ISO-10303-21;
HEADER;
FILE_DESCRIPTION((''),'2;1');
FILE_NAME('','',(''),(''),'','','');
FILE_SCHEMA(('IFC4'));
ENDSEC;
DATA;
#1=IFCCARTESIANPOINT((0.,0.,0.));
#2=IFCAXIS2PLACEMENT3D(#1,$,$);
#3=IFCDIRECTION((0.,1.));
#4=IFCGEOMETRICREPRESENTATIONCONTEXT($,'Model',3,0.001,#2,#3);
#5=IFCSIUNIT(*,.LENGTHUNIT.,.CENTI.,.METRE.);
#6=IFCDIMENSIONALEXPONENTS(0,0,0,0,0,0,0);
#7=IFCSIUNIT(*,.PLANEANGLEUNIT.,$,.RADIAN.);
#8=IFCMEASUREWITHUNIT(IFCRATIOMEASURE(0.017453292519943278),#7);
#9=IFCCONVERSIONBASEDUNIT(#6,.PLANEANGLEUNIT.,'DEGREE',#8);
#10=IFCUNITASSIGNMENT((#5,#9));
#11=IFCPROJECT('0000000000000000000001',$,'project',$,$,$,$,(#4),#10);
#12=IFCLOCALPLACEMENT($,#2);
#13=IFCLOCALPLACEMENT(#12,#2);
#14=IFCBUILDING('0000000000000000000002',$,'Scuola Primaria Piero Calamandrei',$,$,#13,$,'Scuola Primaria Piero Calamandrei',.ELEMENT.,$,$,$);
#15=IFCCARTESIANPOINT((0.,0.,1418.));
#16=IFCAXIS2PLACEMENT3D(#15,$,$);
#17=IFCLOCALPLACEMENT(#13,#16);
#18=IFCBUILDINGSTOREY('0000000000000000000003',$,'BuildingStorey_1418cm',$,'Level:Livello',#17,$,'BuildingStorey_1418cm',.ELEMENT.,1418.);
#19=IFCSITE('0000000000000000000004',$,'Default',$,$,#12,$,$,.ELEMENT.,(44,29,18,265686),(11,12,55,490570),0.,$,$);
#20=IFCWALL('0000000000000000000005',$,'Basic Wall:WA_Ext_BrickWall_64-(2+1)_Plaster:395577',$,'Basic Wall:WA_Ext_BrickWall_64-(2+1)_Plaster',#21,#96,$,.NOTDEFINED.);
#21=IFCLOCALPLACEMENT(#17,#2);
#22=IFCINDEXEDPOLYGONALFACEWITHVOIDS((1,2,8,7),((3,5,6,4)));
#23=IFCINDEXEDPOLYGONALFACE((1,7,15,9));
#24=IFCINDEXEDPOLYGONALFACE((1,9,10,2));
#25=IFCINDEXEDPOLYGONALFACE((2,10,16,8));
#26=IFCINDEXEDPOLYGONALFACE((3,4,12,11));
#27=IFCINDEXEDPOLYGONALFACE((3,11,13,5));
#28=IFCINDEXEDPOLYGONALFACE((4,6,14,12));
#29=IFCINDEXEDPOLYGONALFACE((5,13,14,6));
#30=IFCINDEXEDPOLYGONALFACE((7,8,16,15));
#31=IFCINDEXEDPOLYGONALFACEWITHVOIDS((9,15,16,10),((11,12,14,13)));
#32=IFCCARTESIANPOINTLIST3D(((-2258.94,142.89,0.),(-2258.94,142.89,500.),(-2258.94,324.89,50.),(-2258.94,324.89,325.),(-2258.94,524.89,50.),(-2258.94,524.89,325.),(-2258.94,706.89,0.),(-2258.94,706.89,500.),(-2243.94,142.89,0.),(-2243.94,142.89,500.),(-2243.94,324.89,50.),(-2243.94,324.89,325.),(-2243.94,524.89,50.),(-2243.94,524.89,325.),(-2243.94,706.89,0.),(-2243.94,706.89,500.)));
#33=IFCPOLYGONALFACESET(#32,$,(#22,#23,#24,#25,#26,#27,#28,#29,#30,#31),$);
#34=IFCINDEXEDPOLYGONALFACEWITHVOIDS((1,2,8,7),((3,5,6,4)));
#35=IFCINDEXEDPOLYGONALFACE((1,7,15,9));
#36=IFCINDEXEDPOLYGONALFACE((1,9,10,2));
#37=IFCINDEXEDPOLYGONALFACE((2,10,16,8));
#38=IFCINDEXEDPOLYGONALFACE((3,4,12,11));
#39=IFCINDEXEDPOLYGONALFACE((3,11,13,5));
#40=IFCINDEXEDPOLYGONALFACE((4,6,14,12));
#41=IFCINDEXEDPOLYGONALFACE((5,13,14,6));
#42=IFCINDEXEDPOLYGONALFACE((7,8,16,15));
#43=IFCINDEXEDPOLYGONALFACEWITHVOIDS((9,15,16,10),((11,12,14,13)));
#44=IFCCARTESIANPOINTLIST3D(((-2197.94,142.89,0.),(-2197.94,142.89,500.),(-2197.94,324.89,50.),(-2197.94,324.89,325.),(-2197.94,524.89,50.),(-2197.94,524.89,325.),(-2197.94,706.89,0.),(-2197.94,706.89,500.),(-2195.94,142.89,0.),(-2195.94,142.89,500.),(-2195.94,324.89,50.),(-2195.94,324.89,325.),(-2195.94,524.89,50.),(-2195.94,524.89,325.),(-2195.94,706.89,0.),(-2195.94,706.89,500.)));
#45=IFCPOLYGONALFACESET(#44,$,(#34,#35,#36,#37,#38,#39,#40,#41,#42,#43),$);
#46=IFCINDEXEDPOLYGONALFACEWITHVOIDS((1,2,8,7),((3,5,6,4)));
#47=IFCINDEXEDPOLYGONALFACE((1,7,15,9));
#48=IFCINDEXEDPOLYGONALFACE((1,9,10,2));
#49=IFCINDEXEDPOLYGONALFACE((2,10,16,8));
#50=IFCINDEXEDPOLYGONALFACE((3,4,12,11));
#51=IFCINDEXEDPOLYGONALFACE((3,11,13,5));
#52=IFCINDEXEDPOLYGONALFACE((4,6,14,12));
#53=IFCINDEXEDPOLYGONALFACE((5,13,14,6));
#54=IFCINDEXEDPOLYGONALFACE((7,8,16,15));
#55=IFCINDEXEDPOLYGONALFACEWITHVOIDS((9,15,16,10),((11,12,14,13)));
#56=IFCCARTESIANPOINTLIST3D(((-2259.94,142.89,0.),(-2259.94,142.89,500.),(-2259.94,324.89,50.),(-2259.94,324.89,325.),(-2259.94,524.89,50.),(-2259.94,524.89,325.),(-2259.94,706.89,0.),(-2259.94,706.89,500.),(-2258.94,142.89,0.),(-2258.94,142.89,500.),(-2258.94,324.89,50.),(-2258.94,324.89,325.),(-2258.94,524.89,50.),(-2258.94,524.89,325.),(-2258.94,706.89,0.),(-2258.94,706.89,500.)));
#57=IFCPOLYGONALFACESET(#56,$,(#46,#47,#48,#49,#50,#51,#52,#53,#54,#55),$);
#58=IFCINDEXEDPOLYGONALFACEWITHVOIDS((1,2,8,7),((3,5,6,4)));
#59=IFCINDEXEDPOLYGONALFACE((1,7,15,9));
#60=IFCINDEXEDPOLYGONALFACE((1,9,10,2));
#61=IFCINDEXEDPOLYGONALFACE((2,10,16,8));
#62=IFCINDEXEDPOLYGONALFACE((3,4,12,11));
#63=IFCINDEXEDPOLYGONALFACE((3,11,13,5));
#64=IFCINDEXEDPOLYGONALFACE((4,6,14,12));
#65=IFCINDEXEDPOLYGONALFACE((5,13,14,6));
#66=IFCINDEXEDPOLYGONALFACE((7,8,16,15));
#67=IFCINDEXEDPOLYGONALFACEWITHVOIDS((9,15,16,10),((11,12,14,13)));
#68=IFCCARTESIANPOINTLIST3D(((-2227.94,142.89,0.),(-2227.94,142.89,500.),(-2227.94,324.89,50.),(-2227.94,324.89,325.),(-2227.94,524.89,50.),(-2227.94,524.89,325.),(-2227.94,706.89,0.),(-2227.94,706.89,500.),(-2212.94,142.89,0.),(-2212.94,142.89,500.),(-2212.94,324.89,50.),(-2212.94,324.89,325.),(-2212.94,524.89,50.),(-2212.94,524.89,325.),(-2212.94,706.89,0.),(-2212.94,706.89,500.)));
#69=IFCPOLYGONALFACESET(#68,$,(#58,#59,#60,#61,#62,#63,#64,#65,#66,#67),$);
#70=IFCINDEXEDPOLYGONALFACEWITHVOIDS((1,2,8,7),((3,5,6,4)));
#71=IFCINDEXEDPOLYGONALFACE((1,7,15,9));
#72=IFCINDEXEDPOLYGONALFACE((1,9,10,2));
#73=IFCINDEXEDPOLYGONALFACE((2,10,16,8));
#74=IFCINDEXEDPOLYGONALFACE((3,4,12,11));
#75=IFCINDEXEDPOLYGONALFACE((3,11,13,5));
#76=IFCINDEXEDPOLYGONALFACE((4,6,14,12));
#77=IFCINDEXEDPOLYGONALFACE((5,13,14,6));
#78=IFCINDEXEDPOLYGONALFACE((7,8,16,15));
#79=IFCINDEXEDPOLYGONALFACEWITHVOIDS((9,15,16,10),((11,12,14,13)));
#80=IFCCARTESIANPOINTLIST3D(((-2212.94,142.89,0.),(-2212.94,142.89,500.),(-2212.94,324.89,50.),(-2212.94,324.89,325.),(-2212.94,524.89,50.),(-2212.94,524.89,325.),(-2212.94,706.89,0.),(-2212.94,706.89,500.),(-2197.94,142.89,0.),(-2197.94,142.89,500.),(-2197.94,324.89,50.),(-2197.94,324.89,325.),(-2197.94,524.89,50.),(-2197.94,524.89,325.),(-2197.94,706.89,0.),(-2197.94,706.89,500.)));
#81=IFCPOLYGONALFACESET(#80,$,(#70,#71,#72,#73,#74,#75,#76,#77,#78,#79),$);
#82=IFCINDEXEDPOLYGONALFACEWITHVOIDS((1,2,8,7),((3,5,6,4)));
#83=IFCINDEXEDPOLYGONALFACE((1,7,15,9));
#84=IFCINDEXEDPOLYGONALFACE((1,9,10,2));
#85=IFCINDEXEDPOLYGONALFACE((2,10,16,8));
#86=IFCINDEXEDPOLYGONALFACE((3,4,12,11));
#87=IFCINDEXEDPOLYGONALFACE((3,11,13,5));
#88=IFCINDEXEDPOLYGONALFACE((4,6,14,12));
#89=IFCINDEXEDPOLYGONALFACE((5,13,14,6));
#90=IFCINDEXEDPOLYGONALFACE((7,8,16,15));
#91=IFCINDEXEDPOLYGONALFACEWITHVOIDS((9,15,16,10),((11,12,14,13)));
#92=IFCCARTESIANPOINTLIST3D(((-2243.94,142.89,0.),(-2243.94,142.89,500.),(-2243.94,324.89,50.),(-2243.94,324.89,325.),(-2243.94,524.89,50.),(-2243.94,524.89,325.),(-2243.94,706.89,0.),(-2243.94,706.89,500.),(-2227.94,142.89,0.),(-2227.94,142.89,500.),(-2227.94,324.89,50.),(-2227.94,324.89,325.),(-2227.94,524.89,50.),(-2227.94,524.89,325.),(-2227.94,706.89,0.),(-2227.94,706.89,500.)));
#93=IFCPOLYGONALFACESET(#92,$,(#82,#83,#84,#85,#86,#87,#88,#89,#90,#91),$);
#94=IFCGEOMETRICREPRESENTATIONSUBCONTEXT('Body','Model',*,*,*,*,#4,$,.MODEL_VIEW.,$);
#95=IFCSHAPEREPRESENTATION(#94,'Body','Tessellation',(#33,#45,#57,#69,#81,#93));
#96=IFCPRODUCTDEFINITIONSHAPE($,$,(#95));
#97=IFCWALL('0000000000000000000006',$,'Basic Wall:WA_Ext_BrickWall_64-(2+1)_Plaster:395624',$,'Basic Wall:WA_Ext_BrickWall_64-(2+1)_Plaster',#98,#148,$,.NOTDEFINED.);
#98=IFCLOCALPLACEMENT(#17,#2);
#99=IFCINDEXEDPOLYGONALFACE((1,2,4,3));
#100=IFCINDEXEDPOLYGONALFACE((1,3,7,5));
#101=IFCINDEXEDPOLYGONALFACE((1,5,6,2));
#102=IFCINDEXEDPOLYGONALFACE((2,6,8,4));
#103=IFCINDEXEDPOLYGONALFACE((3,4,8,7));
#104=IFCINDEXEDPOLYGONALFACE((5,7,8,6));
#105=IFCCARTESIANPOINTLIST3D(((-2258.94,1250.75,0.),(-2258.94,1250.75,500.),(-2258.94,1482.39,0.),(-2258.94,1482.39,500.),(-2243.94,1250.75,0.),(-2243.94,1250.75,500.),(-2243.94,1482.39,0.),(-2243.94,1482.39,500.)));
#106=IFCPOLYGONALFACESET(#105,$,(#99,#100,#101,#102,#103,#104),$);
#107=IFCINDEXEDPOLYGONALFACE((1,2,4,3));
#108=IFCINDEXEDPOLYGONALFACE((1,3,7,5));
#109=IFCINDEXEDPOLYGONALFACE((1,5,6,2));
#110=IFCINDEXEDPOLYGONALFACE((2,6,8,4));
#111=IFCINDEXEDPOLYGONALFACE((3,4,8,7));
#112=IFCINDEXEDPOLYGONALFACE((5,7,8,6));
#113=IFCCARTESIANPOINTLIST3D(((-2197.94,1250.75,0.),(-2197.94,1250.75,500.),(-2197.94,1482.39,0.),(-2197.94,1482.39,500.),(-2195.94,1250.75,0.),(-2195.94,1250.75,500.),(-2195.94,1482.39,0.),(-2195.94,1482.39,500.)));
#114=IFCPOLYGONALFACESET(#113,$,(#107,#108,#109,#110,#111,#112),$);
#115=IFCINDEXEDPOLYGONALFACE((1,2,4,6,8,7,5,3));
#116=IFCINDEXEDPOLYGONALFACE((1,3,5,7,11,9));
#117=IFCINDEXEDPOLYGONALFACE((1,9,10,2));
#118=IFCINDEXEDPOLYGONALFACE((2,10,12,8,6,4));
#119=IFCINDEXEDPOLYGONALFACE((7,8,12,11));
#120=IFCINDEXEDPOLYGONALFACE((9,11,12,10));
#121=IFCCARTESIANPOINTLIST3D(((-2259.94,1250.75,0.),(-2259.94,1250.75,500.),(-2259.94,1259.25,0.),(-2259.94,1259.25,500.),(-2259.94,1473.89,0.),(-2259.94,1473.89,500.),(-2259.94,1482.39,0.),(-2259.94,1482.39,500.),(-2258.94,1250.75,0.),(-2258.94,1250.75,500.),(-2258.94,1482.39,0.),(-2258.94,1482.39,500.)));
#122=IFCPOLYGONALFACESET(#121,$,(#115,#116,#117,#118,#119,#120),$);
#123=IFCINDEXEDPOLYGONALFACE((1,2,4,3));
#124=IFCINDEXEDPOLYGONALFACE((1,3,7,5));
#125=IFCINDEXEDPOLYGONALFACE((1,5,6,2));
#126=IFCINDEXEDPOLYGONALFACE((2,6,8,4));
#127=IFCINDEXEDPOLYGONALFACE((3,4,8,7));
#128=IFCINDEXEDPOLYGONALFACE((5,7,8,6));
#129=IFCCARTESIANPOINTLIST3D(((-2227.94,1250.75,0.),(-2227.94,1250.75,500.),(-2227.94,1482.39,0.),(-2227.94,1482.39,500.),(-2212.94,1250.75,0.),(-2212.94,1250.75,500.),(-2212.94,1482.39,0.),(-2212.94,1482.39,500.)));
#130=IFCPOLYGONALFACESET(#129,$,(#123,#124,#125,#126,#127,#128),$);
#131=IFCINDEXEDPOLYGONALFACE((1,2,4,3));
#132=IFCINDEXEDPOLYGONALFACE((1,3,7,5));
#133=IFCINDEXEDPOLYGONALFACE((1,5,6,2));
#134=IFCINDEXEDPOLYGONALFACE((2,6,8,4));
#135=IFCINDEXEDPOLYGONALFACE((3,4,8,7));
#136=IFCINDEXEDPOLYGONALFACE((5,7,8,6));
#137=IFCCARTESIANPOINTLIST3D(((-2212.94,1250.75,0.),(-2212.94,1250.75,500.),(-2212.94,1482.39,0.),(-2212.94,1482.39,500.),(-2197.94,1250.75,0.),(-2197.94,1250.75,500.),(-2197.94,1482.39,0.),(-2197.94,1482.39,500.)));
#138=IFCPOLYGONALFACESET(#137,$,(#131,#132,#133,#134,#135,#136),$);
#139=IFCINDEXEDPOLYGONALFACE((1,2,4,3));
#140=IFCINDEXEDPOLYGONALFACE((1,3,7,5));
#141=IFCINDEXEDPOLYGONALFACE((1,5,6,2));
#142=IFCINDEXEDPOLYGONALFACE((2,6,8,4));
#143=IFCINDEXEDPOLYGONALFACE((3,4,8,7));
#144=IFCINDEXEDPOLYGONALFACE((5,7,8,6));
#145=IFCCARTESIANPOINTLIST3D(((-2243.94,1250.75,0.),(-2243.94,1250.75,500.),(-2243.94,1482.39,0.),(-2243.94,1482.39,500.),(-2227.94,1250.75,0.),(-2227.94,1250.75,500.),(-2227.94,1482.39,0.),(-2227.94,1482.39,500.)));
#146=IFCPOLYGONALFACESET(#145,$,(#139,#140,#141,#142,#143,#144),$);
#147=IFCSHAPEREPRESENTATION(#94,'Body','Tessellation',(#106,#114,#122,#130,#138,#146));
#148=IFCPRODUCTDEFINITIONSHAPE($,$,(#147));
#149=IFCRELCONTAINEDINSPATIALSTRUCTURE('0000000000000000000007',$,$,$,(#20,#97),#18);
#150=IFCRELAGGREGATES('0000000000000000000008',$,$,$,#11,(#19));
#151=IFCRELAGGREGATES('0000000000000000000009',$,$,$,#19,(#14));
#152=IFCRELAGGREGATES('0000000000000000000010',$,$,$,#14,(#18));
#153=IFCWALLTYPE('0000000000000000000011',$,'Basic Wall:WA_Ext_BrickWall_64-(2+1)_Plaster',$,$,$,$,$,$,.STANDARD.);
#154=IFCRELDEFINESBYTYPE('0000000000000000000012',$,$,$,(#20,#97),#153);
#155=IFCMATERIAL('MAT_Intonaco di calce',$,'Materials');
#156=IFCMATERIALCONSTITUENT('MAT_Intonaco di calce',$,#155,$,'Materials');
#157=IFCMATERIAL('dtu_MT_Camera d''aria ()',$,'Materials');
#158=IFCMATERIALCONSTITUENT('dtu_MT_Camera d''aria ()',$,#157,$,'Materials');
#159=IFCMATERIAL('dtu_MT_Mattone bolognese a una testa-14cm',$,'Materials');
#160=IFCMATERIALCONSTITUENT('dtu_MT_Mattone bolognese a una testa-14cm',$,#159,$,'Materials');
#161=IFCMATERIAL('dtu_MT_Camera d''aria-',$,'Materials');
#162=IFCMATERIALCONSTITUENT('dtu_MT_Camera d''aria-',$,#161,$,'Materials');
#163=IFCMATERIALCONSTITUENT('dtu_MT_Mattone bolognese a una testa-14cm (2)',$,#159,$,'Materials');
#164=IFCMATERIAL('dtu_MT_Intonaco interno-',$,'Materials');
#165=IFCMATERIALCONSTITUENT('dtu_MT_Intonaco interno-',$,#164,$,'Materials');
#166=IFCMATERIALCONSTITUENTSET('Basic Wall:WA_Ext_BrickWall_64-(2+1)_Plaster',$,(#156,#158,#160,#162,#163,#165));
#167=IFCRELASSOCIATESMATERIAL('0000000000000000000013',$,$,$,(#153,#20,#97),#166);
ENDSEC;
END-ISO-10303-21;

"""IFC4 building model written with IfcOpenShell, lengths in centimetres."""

from ifc_helpers import new_model, entity, si_unit, converted_unit, direction, frame, origin, place, context, subcontext, project, spatial, indexed_curve, outline, extrude, material, constituent, constituent_set, type_object, element, save


model = new_model("IFC4")

# Units and contexts
model_context = context("Model", 3, precision=0.001, world=origin(), true_north=direction((0.0, 1.0)))
body_context = subcontext(model_context, "Body", "Model", "MODEL_VIEW")
ifc_project = project(units=[si_unit("LENGTHUNIT", "METRE", prefix="CENTI"), converted_unit("PLANEANGLEUNIT", "DEGREE", entity("IfcRatioMeasure", 0.017453292519943278), si_unit("PLANEANGLEUNIT", "RADIAN"), dimensions=[0, 0, 0, 0, 0, 0, 0])], contexts=[model_context])

# Site, building, storey
site_placement = place(None, origin())
site = spatial("IfcSite", under=ifc_project, at=site_placement, Name="Default", CompositionType="ELEMENT", RefLatitude=(44, 29, 18, 265686), RefLongitude=(11, 12, 55, 490570), RefElevation=0.0)
building_placement = place(site_placement, origin())
building = spatial("IfcBuilding", under=site, at=building_placement, Name="Scuola Primaria Piero Calamandrei", LongName="Scuola Primaria Piero Calamandrei", CompositionType="ELEMENT")
storey_placement = place(building_placement, frame((0.0, 0.0, 1418.0)))
storey = spatial("IfcBuildingStorey", under=building, at=storey_placement, Name="BuildingStorey_1418cm", ObjectType="Level:Livello", LongName="BuildingStorey_1418cm", CompositionType="ELEMENT", Elevation=1418.0)

# Shared definitions
ifc_material_1 = material(Name="dtu_MT_Intonaco interno-", Category="Materials")

# Shared definitions
ifc_material_2 = material(Name="MAT_Intonaco di calce", Category="Materials")
ifc_constituent_1 = constituent(ifc_material_2, Name="MAT_Intonaco di calce", Category="Materials")
ifc_material_3 = material(Name="dtu_MT_Camera d'aria ()", Category="Materials")
ifc_constituent_2 = constituent(ifc_material_3, Name="dtu_MT_Camera d'aria ()", Category="Materials")
ifc_material_4 = material(Name="dtu_MT_Mattone bolognese a una testa-14cm", Category="Materials")
ifc_constituent_3 = constituent(ifc_material_4, Name="dtu_MT_Mattone bolognese a una testa-14cm", Category="Materials")
ifc_material_5 = material(Name="dtu_MT_Camera d'aria-", Category="Materials")
ifc_constituent_4 = constituent(ifc_material_5, Name="dtu_MT_Camera d'aria-", Category="Materials")
ifc_constituent_5 = constituent(ifc_material_4, Name="dtu_MT_Mattone bolognese a una testa-14cm (2)", Category="Materials")
ifc_constituent_6 = constituent(ifc_material_1, Name="dtu_MT_Intonaco interno-", Category="Materials")
ifc_constituent_set_1 = constituent_set(constituents=[ifc_constituent_1, ifc_constituent_2, ifc_constituent_3, ifc_constituent_4, ifc_constituent_5, ifc_constituent_6], Name="Basic Wall:WA_Ext_BrickWall_64-(2+1)_Plaster")
wall_type_1 = type_object("IfcWallType", Name="Basic Wall:WA_Ext_BrickWall_64-(2+1)_Plaster", PredefinedType="STANDARD", material=ifc_constituent_set_1)

# Wall, opening
wall_1_placement = place(storey_placement, frame((-2227.94, 706.89, 0.0), z_axis=(0.0, 0.0, 1.0), x_axis=(0.0, -1.0, 0.0)))
wall_1 = element("IfcWall", 1, at=wall_1_placement, inside=storey, type_object=wall_type_1, material=ifc_constituent_set_1, Name="Basic Wall:WA_Ext_BrickWall_64-(2+1)_Plaster:395577", ObjectType="Basic Wall:WA_Ext_BrickWall_64-(2+1)_Plaster", PredefinedType="NOTDEFINED", context=body_context, shape_type="SweptSolid", body=[
    extrude(outline(indexed_curve([(-250.0, -282.0), (250.0, -282.0), (250.0, 282.0), (-250.0, 282.0), (-250.0, -282.0)], self_intersect=False), holes=[indexed_curve([(-200.0, -100.0), (-200.0, 100.0), (75.0, 100.0), (75.0, -100.0), (-200.0, -100.0)], self_intersect=False)]), frame((282.0, -31.0, 250.0), z_axis=(0.0, 1.0, 0.0), x_axis=(0.0, 0.0, 1.0)), (0.0, 0.0, 1.0), 15.0),
    extrude(outline(indexed_curve([(-250.0, -282.0), (250.0, -282.0), (250.0, 282.0), (-250.0, 282.0), (-250.0, -282.0)], self_intersect=False), holes=[indexed_curve([(-200.0, -100.0), (-200.0, 100.0), (75.0, 100.0), (75.0, -100.0), (-200.0, -100.0)], self_intersect=False)]), frame((282.0, 30.0, 250.0), z_axis=(0.0, 1.0, 0.0), x_axis=(0.0, 0.0, 1.0)), (0.0, 0.0, 1.0), 2.0),
    extrude(outline(indexed_curve([(-250.0, -282.0), (250.0, -282.0), (250.0, -273.5), (250.0, 273.5), (250.0, 282.0), (-250.0, 282.0), (-250.0, 273.5), (-250.0, -273.5), (-250.0, -282.0)], self_intersect=False), holes=[indexed_curve([(75.0, -100.0), (-200.0, -100.0), (-200.0, 100.0), (75.0, 100.0), (75.0, -100.0)], self_intersect=False)]), frame((282.0, -32.0, 250.0), z_axis=(0.0, 1.0, 0.0), x_axis=(0.0, 0.0, 1.0)), (0.0, 0.0, 1.0), 1.0),
    extrude(outline(indexed_curve([(-250.0, -282.0), (250.0, -282.0), (250.0, 282.0), (-250.0, 282.0), (-250.0, -282.0)], self_intersect=False), holes=[indexed_curve([(-200.0, -100.0), (-200.0, 100.0), (75.0, 100.0), (75.0, -100.0), (-200.0, -100.0)], self_intersect=False)]), frame((282.0, 0.0, 250.0), z_axis=(0.0, 1.0, 0.0), x_axis=(0.0, 0.0, 1.0)), (0.0, 0.0, 1.0), 15.0),
    extrude(outline(indexed_curve([(-250.0, -282.0), (250.0, -282.0), (250.0, 282.0), (-250.0, 282.0), (-250.0, -282.0)], self_intersect=False), holes=[indexed_curve([(-200.0, -100.0), (-200.0, 100.0), (75.0, 100.0), (75.0, -100.0), (-200.0, -100.0)], self_intersect=False)]), frame((282.0, 15.0, 250.0), z_axis=(0.0, 1.0, 0.0), x_axis=(0.0, 0.0, 1.0)), (0.0, 0.0, 1.0), 15.0),
    extrude(outline(indexed_curve([(-250.0, -282.0), (250.0, -282.0), (250.0, 282.0), (-250.0, 282.0), (-250.0, -282.0)], self_intersect=False), holes=[indexed_curve([(-200.0, -100.0), (-200.0, 100.0), (75.0, 100.0), (75.0, -100.0), (-200.0, -100.0)], self_intersect=False)]), frame((282.0, -16.0, 250.0), z_axis=(0.0, 1.0, 0.0), x_axis=(0.0, 0.0, 1.0)), (0.0, 0.0, 1.0), 16.0),
])
opening_1_placement = place(wall_1_placement, frame((182.0, -32.0, 50.0)))
element("IfcOpeningElement", 2, at=opening_1_placement, cuts=wall_1, PredefinedType="OPENING", context=body_context, shape_type="SweptSolid", body=[
    extrude(outline(indexed_curve([(275.0, 0.0), (275.0, 200.0), (0.0, 200.0), (0.0, 0.0), (275.0, 0.0)], self_intersect=False)), frame((0.0, 0.0, 0.0), z_axis=(0.0, 1.0, 0.0), x_axis=(0.0, 0.0, 1.0)), (0.0, 0.0, 1.0), 64.0),
])

# Wall
wall_2_placement = place(storey_placement, frame((-2227.94, 1482.39, 0.0), z_axis=(0.0, 0.0, 1.0), x_axis=(0.0, -1.0, 0.0)))
element("IfcWall", 3, at=wall_2_placement, inside=storey, type_object=wall_type_1, material=ifc_constituent_set_1, Name="Basic Wall:WA_Ext_BrickWall_64-(2+1)_Plaster:395624", ObjectType="Basic Wall:WA_Ext_BrickWall_64-(2+1)_Plaster", PredefinedType="NOTDEFINED", context=body_context, shape_type="SweptSolid", body=[
    extrude(outline(indexed_curve([(-115.82, -7.5), (115.82, -7.5), (115.82, 7.5), (-115.82, 7.5), (-115.82, -7.5)], self_intersect=False)), frame((115.82, -23.5, 0.0)), (0.0, 0.0, 1.0), 500.0),
    extrude(outline(indexed_curve([(-1.0, -115.82), (1.0, -115.82), (1.0, 115.82), (-1.0, 115.82), (-1.0, -115.82)], self_intersect=False)), frame((115.82, 31.0, 0.0), z_axis=(0.0, 0.0, 1.0), x_axis=(0.0, -1.0, 0.0)), (0.0, 0.0, 1.0), 500.0),
    extrude(outline(indexed_curve([(-107.32, -0.33), (107.32, -0.33), (115.82, -0.33), (115.82, 0.67), (-115.82, 0.67), (-115.82, -0.33), (-107.32, -0.33)], self_intersect=False)), frame((115.82, -31.67, 0.0)), (0.0, 0.0, 1.0), 500.0),
    extrude(outline(indexed_curve([(-115.82, -7.5), (115.82, -7.5), (115.82, 7.5), (-115.82, 7.5), (-115.82, -7.5)], self_intersect=False)), frame((115.82, 7.5, 0.0)), (0.0, 0.0, 1.0), 500.0),
    extrude(outline(indexed_curve([(-115.82, -7.5), (115.82, -7.5), (115.82, 7.5), (-115.82, 7.5), (-115.82, -7.5)], self_intersect=False)), frame((115.82, 22.5, 0.0)), (0.0, 0.0, 1.0), 500.0),
    extrude(outline(indexed_curve([(-115.82, -8.0), (115.82, -8.0), (115.82, 8.0), (-115.82, 8.0), (-115.82, -8.0)], self_intersect=False)), frame((115.82, -8.0, 0.0)), (0.0, 0.0, 1.0), 500.0),
])

save(model, "model.ifc")
